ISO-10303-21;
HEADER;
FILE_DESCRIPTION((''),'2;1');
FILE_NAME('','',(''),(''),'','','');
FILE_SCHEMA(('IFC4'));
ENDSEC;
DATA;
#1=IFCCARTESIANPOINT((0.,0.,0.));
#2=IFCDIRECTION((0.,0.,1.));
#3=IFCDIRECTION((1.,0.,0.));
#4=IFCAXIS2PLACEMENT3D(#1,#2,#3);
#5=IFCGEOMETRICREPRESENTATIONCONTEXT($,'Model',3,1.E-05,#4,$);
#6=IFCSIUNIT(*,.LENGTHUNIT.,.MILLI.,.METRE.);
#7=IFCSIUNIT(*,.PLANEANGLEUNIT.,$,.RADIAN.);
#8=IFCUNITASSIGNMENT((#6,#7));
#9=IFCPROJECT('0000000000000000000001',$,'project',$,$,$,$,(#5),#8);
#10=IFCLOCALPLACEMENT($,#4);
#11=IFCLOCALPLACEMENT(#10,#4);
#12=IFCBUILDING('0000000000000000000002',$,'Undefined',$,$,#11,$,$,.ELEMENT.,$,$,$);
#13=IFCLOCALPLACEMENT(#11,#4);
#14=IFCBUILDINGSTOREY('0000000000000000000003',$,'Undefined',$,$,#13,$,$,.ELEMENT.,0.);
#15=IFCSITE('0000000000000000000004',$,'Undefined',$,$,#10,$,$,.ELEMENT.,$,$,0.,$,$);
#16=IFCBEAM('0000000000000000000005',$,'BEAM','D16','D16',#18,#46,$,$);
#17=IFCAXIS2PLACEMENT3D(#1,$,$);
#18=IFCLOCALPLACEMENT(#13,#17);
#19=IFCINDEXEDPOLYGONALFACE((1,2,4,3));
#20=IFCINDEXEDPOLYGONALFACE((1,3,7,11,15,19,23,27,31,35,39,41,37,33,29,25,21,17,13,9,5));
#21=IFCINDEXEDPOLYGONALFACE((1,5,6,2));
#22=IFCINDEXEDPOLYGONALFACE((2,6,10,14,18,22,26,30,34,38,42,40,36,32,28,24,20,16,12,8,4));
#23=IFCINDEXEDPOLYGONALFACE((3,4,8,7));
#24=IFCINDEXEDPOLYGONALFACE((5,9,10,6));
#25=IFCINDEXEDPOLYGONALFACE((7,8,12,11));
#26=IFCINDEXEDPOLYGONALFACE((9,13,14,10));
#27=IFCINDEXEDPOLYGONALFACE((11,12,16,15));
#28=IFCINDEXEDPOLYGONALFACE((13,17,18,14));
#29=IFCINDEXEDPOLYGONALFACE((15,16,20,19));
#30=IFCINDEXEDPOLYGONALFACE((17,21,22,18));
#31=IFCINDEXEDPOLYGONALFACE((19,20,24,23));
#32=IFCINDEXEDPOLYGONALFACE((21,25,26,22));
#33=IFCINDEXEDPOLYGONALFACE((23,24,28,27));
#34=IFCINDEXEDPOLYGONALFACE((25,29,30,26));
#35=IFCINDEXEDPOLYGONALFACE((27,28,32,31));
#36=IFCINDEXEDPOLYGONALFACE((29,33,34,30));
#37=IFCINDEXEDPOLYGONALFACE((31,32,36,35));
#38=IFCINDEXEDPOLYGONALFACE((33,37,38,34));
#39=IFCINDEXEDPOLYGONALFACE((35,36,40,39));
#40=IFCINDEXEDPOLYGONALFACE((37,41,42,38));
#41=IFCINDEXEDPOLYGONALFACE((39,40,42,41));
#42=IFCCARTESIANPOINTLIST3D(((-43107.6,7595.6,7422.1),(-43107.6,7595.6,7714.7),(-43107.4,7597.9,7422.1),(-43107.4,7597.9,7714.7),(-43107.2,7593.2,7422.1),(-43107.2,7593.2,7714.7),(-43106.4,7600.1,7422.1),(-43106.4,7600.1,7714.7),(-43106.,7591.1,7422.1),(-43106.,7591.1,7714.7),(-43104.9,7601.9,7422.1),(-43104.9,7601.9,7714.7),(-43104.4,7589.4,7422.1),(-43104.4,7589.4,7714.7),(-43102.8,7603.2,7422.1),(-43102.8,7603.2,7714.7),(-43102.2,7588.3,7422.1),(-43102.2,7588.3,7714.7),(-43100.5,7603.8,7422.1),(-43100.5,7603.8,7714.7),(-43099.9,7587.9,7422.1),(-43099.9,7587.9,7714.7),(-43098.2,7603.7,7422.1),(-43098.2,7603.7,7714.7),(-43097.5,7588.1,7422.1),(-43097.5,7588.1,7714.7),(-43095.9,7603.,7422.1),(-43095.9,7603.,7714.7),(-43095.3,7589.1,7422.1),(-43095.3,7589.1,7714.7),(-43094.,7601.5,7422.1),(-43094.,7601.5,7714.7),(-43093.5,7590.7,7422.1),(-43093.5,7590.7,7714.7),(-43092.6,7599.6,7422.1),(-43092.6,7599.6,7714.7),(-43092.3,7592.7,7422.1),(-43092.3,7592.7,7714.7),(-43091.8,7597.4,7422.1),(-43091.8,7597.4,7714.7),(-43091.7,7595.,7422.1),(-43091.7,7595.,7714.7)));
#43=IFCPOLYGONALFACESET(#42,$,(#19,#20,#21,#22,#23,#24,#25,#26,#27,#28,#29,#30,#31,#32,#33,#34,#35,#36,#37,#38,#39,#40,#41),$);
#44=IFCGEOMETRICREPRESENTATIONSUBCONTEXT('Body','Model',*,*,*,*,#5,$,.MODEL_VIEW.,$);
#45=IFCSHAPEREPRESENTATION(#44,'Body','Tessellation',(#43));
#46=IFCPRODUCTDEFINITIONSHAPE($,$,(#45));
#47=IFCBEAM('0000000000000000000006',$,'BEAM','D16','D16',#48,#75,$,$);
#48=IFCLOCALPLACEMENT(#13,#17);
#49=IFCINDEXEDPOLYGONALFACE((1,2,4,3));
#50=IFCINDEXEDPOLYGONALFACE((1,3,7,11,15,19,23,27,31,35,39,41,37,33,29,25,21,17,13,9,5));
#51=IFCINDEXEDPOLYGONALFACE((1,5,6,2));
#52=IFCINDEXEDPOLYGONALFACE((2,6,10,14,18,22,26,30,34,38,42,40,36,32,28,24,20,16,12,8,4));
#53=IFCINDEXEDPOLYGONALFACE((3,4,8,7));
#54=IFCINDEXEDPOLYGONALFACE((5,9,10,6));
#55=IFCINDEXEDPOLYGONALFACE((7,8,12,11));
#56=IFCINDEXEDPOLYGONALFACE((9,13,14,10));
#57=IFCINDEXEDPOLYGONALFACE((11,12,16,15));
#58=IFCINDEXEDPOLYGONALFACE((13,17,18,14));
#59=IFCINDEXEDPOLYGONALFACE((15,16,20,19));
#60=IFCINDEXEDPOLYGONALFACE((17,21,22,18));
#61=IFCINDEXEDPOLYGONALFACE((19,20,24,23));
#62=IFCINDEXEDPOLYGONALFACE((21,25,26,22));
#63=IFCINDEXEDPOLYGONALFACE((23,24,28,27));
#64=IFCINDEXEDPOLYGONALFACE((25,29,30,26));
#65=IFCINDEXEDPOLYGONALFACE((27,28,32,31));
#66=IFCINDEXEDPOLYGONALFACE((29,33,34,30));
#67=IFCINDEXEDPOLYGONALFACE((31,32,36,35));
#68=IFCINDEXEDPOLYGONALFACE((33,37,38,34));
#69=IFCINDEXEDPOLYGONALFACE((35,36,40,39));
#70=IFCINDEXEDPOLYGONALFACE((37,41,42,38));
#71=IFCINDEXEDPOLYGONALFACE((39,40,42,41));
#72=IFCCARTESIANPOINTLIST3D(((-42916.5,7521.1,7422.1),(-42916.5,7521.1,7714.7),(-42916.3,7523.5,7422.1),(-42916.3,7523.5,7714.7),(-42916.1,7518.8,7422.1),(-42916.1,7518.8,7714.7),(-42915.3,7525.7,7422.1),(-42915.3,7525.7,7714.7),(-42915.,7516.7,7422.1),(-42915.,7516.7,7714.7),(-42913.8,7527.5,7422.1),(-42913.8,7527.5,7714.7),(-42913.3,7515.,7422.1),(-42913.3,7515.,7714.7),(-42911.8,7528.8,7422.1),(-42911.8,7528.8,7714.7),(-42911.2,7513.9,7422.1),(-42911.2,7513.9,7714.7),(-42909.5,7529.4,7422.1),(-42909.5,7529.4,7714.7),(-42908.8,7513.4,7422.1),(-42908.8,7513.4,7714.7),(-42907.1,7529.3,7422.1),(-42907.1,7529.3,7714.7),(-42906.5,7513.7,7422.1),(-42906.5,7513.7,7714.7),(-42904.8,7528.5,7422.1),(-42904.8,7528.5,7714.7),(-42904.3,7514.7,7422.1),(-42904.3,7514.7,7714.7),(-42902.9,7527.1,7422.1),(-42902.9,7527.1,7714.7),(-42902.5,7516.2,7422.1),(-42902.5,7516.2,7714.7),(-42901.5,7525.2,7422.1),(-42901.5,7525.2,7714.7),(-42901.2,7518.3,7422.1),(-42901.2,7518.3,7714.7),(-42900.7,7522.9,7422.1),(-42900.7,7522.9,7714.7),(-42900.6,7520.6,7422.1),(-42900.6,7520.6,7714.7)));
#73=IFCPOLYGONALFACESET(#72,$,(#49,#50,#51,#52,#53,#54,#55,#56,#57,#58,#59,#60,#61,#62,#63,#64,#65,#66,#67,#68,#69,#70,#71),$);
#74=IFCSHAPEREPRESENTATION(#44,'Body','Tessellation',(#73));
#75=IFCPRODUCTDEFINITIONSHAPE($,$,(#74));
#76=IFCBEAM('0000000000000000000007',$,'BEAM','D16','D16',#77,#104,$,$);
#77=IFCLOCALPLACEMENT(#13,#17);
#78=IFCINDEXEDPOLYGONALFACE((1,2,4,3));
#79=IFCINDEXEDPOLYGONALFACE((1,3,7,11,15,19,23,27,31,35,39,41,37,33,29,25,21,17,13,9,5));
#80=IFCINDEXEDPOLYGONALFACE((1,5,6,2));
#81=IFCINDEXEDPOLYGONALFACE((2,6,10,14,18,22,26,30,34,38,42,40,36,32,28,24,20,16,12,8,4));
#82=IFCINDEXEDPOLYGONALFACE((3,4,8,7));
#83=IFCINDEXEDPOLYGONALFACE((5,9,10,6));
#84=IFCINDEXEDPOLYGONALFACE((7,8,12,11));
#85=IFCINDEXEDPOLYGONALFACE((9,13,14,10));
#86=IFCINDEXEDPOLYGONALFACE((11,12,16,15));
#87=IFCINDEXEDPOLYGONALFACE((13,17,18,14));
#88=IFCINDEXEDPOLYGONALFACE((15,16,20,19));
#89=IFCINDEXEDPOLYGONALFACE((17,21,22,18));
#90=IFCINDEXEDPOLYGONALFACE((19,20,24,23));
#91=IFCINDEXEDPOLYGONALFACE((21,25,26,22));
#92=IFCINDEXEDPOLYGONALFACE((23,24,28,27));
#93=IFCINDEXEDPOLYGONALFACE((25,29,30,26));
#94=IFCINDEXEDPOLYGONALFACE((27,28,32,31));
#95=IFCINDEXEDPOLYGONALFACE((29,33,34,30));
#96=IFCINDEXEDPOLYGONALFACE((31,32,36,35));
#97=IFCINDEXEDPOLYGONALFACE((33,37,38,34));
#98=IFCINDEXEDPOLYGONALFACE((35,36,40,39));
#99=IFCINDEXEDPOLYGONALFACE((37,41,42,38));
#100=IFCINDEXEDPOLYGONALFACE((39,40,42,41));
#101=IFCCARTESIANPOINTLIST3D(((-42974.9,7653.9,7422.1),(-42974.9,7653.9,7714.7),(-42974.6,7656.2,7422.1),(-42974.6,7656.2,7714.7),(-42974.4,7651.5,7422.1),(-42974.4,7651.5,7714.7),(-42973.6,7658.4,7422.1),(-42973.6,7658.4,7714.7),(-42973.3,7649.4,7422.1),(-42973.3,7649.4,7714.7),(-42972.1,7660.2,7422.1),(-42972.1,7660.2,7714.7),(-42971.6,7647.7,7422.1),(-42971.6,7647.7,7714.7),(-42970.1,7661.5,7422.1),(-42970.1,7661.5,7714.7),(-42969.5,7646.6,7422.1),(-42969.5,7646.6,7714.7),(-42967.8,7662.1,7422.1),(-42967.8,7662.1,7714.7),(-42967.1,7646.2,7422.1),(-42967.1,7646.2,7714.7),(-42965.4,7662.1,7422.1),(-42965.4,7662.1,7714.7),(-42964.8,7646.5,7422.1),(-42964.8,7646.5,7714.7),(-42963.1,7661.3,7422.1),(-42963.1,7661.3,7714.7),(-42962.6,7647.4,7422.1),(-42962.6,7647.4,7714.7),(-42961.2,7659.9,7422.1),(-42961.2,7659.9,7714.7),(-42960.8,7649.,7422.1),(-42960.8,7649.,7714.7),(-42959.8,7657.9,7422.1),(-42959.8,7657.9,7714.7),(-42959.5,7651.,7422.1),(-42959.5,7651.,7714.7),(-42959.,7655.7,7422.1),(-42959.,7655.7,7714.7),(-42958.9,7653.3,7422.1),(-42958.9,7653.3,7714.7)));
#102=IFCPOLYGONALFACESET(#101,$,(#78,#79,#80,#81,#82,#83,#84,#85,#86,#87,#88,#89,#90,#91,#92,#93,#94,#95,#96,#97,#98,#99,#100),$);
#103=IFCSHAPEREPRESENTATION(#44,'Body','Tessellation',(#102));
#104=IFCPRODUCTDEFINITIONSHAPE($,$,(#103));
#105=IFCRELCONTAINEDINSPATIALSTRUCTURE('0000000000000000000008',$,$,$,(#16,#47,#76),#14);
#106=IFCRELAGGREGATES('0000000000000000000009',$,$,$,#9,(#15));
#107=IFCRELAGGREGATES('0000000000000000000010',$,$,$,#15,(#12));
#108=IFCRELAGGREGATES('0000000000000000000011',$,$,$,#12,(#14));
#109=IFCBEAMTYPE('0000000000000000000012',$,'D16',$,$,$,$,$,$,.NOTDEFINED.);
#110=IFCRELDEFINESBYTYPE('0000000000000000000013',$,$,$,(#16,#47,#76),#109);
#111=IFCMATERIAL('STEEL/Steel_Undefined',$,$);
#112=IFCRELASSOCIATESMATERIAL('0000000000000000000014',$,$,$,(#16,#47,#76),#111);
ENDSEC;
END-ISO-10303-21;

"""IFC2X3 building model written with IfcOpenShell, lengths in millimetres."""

from ifc_helpers import new_model, si_unit, frame, origin_with_axes, origin_2d_with_axis, place, context, subcontext, project, spatial, circle, extrude, material, type_object, element, save


model = new_model("IFC2X3")

# Units and contexts
model_context = context("Model", 3, precision=1e-05, world=origin_with_axes())
body_context = subcontext(model_context, "Body", "Model", "MODEL_VIEW")
ifc_project = project(units=[si_unit("LENGTHUNIT", "METRE", prefix="MILLI"), si_unit("PLANEANGLEUNIT", "RADIAN")], contexts=[model_context])

# Site, building, storey
site_placement = place(None, origin_with_axes())
site = spatial("IfcSite", under=ifc_project, at=site_placement, Name="Undefined", CompositionType="ELEMENT", RefElevation=0.0)
building_placement = place(site_placement, origin_with_axes())
building = spatial("IfcBuilding", under=site, at=building_placement, Name="Undefined", CompositionType="ELEMENT")
storey_placement = place(building_placement, origin_with_axes())
storey = spatial("IfcBuildingStorey", under=building, at=storey_placement, Name="Undefined", CompositionType="ELEMENT", Elevation=0.0)

# Shared definitions
ifc_material_1 = material(Name="STEEL/Steel_Undefined")

# Beams
beam_type_1 = type_object("IfcBeamType", Name="D16", PredefinedType="NOTDEFINED")
for number, where, z_axis, x_axis, name in (
    (1, (-43099.6, 7595.9, 7714.7), (-0.915553, -0.402198, 0.0), (0.0, 0.0, -1.0), "BEAM"),
    (2, (-42908.5, 7521.4, 7714.7), (-0.915553, -0.402198, 0.0), (0.0, 0.0, -1.0), "BEAM"),
    (3, (-42966.9, 7654.2, 7714.7), (-0.915553, -0.402198, 0.0), (0.0, 0.0, -1.0), "BEAM"),
):
    element("IfcBeam", number, at=place(storey_placement, frame(where, z_axis=z_axis, x_axis=x_axis)), inside=storey, type_object=beam_type_1, material=ifc_material_1, Name=name, Description="D16", ObjectType="D16", context=body_context, shape_type="SweptSolid", body=[
        extrude(circle(Radius=8.0, at=origin_2d_with_axis()), frame((292.6, 0.0, 0.0), z_axis=(-1.0, 0.0, 0.0), x_axis=(0.0, -1.0, 0.0)), (0.0, 0.0, 1.0), 292.6),
    ])

save(model, "model.ifc")
